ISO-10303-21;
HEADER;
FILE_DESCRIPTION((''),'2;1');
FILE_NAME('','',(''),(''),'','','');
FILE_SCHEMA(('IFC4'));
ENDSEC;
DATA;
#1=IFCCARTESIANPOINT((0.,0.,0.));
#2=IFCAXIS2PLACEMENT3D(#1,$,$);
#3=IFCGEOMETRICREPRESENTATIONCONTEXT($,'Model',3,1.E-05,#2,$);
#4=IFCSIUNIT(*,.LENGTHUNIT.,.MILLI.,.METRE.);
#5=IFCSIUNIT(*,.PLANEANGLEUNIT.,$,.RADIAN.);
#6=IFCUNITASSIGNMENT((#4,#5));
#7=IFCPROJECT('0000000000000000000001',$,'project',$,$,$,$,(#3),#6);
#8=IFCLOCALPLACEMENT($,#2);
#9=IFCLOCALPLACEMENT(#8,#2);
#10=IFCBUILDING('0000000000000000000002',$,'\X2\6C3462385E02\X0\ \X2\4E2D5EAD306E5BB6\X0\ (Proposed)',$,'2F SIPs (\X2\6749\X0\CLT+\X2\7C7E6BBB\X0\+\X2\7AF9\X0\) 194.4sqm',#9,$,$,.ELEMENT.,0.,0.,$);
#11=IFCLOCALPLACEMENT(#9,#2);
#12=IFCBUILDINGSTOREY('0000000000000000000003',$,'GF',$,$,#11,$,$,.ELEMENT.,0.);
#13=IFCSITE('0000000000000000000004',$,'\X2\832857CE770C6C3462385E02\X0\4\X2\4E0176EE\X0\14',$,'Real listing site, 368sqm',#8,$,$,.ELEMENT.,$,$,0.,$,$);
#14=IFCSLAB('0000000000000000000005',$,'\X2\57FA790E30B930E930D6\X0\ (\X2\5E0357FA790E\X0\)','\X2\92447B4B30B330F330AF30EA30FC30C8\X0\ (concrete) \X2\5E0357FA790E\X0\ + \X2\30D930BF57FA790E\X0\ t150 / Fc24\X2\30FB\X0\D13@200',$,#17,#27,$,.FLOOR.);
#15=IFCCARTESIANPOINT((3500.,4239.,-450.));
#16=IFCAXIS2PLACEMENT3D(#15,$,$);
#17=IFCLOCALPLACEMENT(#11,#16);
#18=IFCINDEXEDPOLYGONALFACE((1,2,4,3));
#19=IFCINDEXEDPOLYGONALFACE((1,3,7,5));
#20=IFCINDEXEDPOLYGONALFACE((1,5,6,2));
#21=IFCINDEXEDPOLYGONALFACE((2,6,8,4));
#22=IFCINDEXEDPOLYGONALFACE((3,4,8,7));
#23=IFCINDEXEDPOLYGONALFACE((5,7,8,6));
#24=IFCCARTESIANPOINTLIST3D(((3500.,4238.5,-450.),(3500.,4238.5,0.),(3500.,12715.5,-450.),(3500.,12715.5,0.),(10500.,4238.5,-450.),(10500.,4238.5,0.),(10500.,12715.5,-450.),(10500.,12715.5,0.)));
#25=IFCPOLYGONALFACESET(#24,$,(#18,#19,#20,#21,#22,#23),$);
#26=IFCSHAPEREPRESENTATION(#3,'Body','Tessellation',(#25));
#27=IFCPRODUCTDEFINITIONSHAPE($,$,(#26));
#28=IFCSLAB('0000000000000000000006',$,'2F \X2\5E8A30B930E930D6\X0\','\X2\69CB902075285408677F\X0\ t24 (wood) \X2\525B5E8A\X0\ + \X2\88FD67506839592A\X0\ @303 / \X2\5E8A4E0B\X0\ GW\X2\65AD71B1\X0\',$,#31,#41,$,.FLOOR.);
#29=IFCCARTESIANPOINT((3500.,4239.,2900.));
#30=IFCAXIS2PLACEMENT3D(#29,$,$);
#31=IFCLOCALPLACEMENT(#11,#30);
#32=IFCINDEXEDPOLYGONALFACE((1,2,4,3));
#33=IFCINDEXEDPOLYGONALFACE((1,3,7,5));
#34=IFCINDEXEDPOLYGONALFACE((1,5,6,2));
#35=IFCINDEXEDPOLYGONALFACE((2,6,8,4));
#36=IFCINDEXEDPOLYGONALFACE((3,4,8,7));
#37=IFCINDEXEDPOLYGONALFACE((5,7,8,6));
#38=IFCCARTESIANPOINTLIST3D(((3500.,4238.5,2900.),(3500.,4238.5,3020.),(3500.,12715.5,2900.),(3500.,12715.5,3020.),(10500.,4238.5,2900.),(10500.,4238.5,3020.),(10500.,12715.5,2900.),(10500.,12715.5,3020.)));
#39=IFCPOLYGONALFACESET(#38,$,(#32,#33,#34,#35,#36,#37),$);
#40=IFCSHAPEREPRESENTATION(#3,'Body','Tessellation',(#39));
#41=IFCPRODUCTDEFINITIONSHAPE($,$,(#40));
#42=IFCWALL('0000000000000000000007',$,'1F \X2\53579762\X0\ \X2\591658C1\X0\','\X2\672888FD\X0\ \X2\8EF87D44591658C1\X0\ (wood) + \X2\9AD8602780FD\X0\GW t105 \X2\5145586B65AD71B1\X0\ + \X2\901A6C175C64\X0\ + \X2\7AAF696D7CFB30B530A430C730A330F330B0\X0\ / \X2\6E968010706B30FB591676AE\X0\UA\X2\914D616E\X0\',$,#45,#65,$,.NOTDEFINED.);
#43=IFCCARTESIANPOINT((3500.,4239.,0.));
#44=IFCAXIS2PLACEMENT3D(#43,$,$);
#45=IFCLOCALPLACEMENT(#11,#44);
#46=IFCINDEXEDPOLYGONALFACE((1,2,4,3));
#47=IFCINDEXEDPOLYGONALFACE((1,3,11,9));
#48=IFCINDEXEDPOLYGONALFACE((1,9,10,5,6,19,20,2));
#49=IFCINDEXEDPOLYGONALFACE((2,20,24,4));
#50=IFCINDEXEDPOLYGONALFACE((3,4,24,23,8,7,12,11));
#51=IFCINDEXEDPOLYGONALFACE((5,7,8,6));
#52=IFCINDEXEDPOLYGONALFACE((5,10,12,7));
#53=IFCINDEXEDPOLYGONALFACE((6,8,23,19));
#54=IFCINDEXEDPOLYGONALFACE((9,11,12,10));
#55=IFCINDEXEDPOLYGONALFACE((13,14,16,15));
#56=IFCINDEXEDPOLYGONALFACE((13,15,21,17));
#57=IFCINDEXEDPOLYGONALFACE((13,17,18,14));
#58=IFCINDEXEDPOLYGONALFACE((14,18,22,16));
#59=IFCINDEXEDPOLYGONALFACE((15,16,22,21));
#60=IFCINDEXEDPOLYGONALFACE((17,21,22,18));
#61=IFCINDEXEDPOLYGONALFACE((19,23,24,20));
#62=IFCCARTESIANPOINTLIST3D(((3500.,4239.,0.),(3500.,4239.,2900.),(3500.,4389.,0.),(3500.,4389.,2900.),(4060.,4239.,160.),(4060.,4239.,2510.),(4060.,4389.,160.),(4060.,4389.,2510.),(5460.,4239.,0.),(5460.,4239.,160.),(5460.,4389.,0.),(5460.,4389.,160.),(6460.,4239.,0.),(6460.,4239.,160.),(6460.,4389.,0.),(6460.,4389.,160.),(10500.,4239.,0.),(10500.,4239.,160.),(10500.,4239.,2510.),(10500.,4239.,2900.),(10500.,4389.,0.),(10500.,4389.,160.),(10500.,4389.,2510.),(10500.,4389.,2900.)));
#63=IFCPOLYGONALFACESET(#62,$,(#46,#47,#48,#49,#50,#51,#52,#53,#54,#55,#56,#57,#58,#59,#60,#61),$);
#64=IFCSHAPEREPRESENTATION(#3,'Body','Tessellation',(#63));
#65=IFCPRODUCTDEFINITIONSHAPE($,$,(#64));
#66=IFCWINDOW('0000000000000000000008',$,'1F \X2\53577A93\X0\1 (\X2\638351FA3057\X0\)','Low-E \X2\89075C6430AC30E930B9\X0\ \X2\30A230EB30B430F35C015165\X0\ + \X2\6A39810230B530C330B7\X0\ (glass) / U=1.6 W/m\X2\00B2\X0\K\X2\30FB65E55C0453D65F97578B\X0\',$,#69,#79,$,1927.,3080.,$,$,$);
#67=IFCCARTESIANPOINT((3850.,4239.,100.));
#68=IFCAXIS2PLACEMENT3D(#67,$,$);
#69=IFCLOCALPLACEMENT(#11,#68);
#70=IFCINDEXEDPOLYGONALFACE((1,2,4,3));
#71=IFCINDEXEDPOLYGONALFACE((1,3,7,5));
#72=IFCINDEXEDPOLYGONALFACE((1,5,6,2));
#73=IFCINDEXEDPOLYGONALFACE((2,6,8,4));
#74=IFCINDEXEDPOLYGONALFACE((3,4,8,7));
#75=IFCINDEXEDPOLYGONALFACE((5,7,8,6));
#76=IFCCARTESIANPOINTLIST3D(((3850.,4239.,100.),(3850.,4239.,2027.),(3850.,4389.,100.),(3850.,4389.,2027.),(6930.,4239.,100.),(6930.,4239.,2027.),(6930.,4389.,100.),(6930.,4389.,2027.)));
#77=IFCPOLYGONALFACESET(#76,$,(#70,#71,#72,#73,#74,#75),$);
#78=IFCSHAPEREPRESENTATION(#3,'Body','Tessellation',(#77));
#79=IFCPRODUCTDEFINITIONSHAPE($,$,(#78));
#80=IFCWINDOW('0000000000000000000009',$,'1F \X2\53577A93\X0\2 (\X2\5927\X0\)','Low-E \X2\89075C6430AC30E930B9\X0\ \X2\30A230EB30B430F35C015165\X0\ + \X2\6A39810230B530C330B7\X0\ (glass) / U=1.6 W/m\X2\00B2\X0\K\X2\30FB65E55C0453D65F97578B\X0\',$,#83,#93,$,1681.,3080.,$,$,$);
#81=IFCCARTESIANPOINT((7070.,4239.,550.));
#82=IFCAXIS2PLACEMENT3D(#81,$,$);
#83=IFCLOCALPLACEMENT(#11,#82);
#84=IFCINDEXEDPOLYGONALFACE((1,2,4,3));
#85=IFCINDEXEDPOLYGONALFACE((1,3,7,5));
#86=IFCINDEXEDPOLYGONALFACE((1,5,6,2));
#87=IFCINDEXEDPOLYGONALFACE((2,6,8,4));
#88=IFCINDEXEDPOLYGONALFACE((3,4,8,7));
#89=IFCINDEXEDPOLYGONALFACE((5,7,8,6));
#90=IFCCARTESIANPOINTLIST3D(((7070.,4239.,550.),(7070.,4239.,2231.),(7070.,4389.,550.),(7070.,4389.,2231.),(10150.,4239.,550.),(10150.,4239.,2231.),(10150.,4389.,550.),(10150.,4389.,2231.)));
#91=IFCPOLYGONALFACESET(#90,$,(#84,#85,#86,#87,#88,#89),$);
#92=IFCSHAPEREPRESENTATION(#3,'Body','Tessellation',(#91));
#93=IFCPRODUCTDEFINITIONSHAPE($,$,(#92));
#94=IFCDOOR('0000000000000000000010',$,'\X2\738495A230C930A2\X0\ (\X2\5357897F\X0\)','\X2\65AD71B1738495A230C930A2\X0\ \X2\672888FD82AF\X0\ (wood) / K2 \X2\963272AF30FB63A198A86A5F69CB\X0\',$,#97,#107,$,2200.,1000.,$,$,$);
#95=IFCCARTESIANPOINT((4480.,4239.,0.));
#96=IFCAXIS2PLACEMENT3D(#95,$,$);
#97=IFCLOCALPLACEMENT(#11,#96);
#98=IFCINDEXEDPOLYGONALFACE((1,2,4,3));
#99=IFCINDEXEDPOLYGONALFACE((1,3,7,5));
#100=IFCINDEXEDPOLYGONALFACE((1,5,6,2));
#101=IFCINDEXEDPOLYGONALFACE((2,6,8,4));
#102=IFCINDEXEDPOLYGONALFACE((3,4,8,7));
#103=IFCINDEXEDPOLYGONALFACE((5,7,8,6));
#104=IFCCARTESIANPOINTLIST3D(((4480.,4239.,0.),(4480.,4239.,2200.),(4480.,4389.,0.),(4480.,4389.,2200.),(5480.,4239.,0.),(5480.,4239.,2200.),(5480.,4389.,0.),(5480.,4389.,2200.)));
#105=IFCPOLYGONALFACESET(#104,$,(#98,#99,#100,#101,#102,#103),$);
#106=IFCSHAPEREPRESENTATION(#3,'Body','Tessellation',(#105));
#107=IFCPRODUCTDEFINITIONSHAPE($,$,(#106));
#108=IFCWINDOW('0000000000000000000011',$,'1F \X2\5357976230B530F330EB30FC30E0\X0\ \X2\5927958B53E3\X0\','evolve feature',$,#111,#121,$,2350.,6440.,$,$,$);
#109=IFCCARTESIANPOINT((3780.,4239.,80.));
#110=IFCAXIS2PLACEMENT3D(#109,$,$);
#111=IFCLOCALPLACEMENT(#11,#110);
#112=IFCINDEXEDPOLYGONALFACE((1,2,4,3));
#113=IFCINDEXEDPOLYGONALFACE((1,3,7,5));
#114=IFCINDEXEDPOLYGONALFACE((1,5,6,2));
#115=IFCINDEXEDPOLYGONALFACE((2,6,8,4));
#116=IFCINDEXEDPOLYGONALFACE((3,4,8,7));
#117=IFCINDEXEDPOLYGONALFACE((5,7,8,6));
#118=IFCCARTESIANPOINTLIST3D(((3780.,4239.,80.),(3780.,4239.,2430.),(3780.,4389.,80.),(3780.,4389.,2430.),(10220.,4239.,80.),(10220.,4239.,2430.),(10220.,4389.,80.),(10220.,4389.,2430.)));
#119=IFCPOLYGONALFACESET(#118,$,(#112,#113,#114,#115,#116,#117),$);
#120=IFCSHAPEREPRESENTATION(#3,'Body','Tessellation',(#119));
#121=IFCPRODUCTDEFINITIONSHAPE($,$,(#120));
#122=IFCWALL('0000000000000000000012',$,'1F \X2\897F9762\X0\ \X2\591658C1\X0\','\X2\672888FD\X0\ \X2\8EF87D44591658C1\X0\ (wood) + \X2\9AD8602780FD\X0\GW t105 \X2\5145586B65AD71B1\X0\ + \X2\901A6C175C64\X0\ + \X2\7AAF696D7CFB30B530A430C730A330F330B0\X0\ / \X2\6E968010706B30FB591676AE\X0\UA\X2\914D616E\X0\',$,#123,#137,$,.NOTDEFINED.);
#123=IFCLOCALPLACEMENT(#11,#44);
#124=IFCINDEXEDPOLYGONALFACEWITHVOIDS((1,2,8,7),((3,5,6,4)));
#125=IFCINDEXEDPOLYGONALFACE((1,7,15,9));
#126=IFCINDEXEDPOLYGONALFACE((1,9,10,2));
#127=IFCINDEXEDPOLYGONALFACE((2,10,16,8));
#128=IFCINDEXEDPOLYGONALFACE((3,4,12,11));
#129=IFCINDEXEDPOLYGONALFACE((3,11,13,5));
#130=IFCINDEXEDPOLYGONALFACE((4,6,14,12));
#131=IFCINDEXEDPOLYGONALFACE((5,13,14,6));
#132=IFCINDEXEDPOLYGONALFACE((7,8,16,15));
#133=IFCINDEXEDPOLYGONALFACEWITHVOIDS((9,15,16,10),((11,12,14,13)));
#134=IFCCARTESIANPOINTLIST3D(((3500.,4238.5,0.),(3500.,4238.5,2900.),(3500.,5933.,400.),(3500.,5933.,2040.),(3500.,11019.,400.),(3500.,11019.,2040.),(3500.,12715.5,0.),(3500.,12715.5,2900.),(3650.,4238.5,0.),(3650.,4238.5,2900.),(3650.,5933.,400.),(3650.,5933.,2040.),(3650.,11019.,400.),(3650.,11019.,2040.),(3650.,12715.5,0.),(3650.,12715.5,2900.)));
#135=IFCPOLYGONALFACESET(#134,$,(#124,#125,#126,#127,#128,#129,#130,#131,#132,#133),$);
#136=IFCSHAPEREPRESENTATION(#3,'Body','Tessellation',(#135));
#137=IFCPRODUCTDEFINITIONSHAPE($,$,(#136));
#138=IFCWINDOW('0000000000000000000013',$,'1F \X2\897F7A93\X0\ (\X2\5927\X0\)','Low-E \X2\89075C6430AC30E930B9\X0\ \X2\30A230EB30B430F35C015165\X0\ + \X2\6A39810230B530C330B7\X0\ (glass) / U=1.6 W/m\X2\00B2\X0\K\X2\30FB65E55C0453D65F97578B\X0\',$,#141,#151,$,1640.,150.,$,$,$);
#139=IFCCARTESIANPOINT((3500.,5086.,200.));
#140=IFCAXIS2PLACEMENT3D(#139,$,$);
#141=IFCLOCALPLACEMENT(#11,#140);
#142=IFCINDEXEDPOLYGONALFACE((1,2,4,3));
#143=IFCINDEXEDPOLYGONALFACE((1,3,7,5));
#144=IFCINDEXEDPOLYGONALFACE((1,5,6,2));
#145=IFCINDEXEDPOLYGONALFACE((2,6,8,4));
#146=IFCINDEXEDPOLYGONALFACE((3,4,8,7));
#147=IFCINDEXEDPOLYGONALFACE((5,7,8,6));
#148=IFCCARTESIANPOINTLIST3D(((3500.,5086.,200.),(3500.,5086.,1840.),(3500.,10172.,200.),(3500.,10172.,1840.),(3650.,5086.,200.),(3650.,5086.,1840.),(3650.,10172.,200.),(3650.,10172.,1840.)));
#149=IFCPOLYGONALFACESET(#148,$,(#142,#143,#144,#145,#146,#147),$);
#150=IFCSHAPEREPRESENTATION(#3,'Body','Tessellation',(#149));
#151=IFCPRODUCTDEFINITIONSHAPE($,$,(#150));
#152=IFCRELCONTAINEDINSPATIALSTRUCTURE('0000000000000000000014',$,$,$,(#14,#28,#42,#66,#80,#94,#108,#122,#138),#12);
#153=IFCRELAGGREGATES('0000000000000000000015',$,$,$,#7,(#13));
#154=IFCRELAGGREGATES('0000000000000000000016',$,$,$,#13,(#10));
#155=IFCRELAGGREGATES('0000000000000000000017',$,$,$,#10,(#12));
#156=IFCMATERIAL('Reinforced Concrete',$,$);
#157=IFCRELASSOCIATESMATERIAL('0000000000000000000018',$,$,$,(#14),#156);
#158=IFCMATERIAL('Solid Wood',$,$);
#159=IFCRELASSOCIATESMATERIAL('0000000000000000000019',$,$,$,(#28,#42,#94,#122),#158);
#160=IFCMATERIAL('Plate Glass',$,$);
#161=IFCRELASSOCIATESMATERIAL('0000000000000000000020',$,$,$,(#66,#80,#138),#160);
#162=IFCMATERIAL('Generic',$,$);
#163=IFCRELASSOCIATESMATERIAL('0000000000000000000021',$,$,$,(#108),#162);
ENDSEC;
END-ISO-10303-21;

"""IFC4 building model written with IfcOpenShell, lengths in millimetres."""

from ifc_helpers import new_model, si_unit, frame, frame_2d, origin, place, context, project, spatial, rectangle, extrude, material, element, fill, save


model = new_model("IFC4")

# Units and contexts
model_context = context("Model", 3, precision=1e-05, world=origin())
ifc_project = project(units=[si_unit("LENGTHUNIT", "METRE", prefix="MILLI"), si_unit("PLANEANGLEUNIT", "RADIAN")], contexts=[model_context])

# Site, building, storey
site_placement = place(None, origin())
site = spatial("IfcSite", under=ifc_project, at=site_placement, Name="茨城県水戸市4丁目14", ObjectType="Real listing site, 368sqm", CompositionType="ELEMENT", RefElevation=0.0)
building_placement = place(site_placement, origin())
building = spatial("IfcBuilding", under=site, at=building_placement, Name="水戸市 中庭の家 (Proposed)", ObjectType="2F SIPs (杉CLT+籾殻+竹) 194.4sqm", CompositionType="ELEMENT", ElevationOfRefHeight=0.0, ElevationOfTerrain=0.0)
storey_placement = place(building_placement, origin())
storey = spatial("IfcBuildingStorey", under=building, at=storey_placement, Name="GF", CompositionType="ELEMENT", Elevation=0.0)

# Slabs
ifc_material_1 = material(Name="Reinforced Concrete")
slab_1_placement = place(storey_placement, frame((3500.0, 4239.0, -450.0)))
element("IfcSlab", 1, at=slab_1_placement, inside=storey, material=ifc_material_1, Name="基礎スラブ (布基礎)", Description="鉄筋コンクリート (concrete) 布基礎 + ベタ基礎 t150 / Fc24・D13@200", PredefinedType="FLOOR", context=model_context, shape_type="SweptSolid", body=[
    extrude(rectangle(XDim=7000.0, YDim=8477.0, at=frame_2d((3500.0, 4238.0))), frame((3500.0, 4239.0, -450.0)), (0.0, 0.0, 1.0), 450.0),
])
ifc_material_2 = material(Name="Solid Wood")
slab_2_placement = place(storey_placement, frame((3500.0, 4239.0, 2900.0)))
element("IfcSlab", 2, at=slab_2_placement, inside=storey, material=ifc_material_2, Name="2F 床スラブ", Description="構造用合板 t24 (wood) 剛床 + 製材根太 @303 / 床下 GW断熱", PredefinedType="FLOOR", context=model_context, shape_type="SweptSolid", body=[
    extrude(rectangle(XDim=7000.0, YDim=8477.0, at=frame_2d((3500.0, 4238.0))), frame((3500.0, 4239.0, 2900.0)), (0.0, 0.0, 1.0), 120.0),
])
ifc_material_3 = material(Name="Generic")

# Wall, openings, windows, door
wall_1_placement = place(storey_placement, frame((3500.0, 4239.0, 0.0)))
wall_1 = element("IfcWall", 3, at=wall_1_placement, inside=storey, material=ifc_material_2, Name="1F 南面 外壁", Description="木製 軸組外壁 (wood) + 高性能GW t105 充填断熱 + 通気層 + 窯業系サイディング / 準耐火・外皮UA配慮", PredefinedType="NOTDEFINED", context=model_context, shape_type="SweptSolid", body=[
    extrude(rectangle(XDim=7000.0, YDim=150.0, at=frame_2d((3500.0, 75.0))), frame((3500.0, 4239.0, 0.0)), (0.0, 0.0, 1.0), 2900.0),
])
opening_1_placement = place(storey_placement, frame((3850.0, 4239.0, 100.0)))
opening_1 = element("IfcOpeningElement", 4, at=opening_1_placement, cuts=wall_1, PredefinedType="NOTDEFINED", context=model_context, shape_type="SweptSolid", body=[
    extrude(rectangle(XDim=3080.0, YDim=150.0, at=frame_2d((1540.0, 75.0))), frame((3850.0, 4239.0, 100.0)), (0.0, 0.0, 1.0), 1927.0),
])
opening_2_placement = place(storey_placement, frame((7070.0, 4239.0, 550.0)))
opening_2 = element("IfcOpeningElement", 5, at=opening_2_placement, cuts=wall_1, PredefinedType="NOTDEFINED", context=model_context, shape_type="SweptSolid", body=[
    extrude(rectangle(XDim=3080.0, YDim=150.0, at=frame_2d((1540.0, 75.0))), frame((7070.0, 4239.0, 550.0)), (0.0, 0.0, 1.0), 1681.0),
])
opening_3_placement = place(storey_placement, frame((4480.0, 4239.0, 0.0)))
opening_3 = element("IfcOpeningElement", 6, at=opening_3_placement, cuts=wall_1, PredefinedType="NOTDEFINED", context=model_context, shape_type="SweptSolid", body=[
    extrude(rectangle(XDim=1000.0, YDim=150.0, at=frame_2d((500.0, 75.0))), frame((4480.0, 4239.0, 0.0)), (0.0, 0.0, 1.0), 2200.0),
])
opening_4_placement = place(storey_placement, frame((3780.0, 4239.0, 80.0)))
opening_4 = element("IfcOpeningElement", 7, at=opening_4_placement, cuts=wall_1, PredefinedType="NOTDEFINED", context=model_context, shape_type="SweptSolid", body=[
    extrude(rectangle(XDim=6440.0, YDim=150.0, at=frame_2d((3220.0, 75.0))), frame((3780.0, 4239.0, 80.0)), (0.0, 0.0, 1.0), 2350.0),
])
ifc_material_4 = material(Name="Plate Glass")
window_1_placement = place(storey_placement, frame((3850.0, 4239.0, 100.0)))
window_1 = element("IfcWindow", 8, at=window_1_placement, inside=storey, material=ifc_material_4, Name="1F 南窓1 (掃出し)", Description="Low-E 複層ガラス アルゴン封入 + 樹脂サッシ (glass) / U=1.6 W/m²K・日射取得型", OverallHeight=1927.0, OverallWidth=3080.0, context=model_context, shape_type="SweptSolid", body=[
    extrude(rectangle(XDim=3080.0, YDim=150.0, at=frame_2d((1540.0, 75.0))), frame((3850.0, 4239.0, 100.0)), (0.0, 0.0, 1.0), 1927.0),
])
fill(opening_1, window_1)
window_2_placement = place(storey_placement, frame((7070.0, 4239.0, 550.0)))
window_2 = element("IfcWindow", 9, at=window_2_placement, inside=storey, material=ifc_material_4, Name="1F 南窓2 (大)", Description="Low-E 複層ガラス アルゴン封入 + 樹脂サッシ (glass) / U=1.6 W/m²K・日射取得型", OverallHeight=1681.0, OverallWidth=3080.0, context=model_context, shape_type="SweptSolid", body=[
    extrude(rectangle(XDim=3080.0, YDim=150.0, at=frame_2d((1540.0, 75.0))), frame((7070.0, 4239.0, 550.0)), (0.0, 0.0, 1.0), 1681.0),
])
fill(opening_2, window_2)
door_placement = place(storey_placement, frame((4480.0, 4239.0, 0.0)))
door = element("IfcDoor", 10, at=door_placement, inside=storey, material=ifc_material_2, Name="玄関ドア (南西)", Description="断熱玄関ドア 木製芯 (wood) / K2 防犯・採風機構", OverallHeight=2200.0, OverallWidth=1000.0, context=model_context, shape_type="SweptSolid", body=[
    extrude(rectangle(XDim=1000.0, YDim=150.0, at=frame_2d((500.0, 75.0))), frame((4480.0, 4239.0, 0.0)), (0.0, 0.0, 1.0), 2200.0),
])
fill(opening_3, door)
window_3_placement = place(storey_placement, frame((3780.0, 4239.0, 80.0)))
window_3 = element("IfcWindow", 11, at=window_3_placement, inside=storey, material=ifc_material_3, Name="1F 南面サンルーム 大開口", Description="evolve feature", OverallHeight=2350.0, OverallWidth=6440.0, context=model_context, shape_type="SweptSolid", body=[
    extrude(rectangle(XDim=6440.0, YDim=150.0, at=frame_2d((3220.0, 75.0))), frame((3780.0, 4239.0, 80.0)), (0.0, 0.0, 1.0), 2350.0),
])
fill(opening_4, window_3)

# Wall, opening, window
wall_2_placement = place(storey_placement, frame((3500.0, 4239.0, 0.0)))
wall_2 = element("IfcWall", 12, at=wall_2_placement, inside=storey, material=ifc_material_2, Name="1F 西面 外壁", Description="木製 軸組外壁 (wood) + 高性能GW t105 充填断熱 + 通気層 + 窯業系サイディング / 準耐火・外皮UA配慮", PredefinedType="NOTDEFINED", context=model_context, shape_type="SweptSolid", body=[
    extrude(rectangle(XDim=150.0, YDim=8477.0, at=frame_2d((75.0, 4238.0))), frame((3500.0, 4239.0, 0.0)), (0.0, 0.0, 1.0), 2900.0),
])
opening_5_placement = place(storey_placement, frame((3500.0, 5086.0, 200.0)))
opening_5 = element("IfcOpeningElement", 13, at=opening_5_placement, cuts=wall_2, PredefinedType="NOTDEFINED", context=model_context, shape_type="SweptSolid", body=[
    extrude(rectangle(XDim=150.0, YDim=5086.0, at=frame_2d((75.0, 2543.0))), frame((3500.0, 5086.0, 200.0)), (0.0, 0.0, 1.0), 1640.0),
])
window_4_placement = place(storey_placement, frame((3500.0, 5086.0, 200.0)))
window_4 = element("IfcWindow", 14, at=window_4_placement, inside=storey, material=ifc_material_4, Name="1F 西窓 (大)", Description="Low-E 複層ガラス アルゴン封入 + 樹脂サッシ (glass) / U=1.6 W/m²K・日射取得型", OverallHeight=1640.0, OverallWidth=150.0, context=model_context, shape_type="SweptSolid", body=[
    extrude(rectangle(XDim=150.0, YDim=5086.0, at=frame_2d((75.0, 2543.0))), frame((3500.0, 5086.0, 200.0)), (0.0, 0.0, 1.0), 1640.0),
])
fill(opening_5, window_4)

save(model, "model.ifc")
